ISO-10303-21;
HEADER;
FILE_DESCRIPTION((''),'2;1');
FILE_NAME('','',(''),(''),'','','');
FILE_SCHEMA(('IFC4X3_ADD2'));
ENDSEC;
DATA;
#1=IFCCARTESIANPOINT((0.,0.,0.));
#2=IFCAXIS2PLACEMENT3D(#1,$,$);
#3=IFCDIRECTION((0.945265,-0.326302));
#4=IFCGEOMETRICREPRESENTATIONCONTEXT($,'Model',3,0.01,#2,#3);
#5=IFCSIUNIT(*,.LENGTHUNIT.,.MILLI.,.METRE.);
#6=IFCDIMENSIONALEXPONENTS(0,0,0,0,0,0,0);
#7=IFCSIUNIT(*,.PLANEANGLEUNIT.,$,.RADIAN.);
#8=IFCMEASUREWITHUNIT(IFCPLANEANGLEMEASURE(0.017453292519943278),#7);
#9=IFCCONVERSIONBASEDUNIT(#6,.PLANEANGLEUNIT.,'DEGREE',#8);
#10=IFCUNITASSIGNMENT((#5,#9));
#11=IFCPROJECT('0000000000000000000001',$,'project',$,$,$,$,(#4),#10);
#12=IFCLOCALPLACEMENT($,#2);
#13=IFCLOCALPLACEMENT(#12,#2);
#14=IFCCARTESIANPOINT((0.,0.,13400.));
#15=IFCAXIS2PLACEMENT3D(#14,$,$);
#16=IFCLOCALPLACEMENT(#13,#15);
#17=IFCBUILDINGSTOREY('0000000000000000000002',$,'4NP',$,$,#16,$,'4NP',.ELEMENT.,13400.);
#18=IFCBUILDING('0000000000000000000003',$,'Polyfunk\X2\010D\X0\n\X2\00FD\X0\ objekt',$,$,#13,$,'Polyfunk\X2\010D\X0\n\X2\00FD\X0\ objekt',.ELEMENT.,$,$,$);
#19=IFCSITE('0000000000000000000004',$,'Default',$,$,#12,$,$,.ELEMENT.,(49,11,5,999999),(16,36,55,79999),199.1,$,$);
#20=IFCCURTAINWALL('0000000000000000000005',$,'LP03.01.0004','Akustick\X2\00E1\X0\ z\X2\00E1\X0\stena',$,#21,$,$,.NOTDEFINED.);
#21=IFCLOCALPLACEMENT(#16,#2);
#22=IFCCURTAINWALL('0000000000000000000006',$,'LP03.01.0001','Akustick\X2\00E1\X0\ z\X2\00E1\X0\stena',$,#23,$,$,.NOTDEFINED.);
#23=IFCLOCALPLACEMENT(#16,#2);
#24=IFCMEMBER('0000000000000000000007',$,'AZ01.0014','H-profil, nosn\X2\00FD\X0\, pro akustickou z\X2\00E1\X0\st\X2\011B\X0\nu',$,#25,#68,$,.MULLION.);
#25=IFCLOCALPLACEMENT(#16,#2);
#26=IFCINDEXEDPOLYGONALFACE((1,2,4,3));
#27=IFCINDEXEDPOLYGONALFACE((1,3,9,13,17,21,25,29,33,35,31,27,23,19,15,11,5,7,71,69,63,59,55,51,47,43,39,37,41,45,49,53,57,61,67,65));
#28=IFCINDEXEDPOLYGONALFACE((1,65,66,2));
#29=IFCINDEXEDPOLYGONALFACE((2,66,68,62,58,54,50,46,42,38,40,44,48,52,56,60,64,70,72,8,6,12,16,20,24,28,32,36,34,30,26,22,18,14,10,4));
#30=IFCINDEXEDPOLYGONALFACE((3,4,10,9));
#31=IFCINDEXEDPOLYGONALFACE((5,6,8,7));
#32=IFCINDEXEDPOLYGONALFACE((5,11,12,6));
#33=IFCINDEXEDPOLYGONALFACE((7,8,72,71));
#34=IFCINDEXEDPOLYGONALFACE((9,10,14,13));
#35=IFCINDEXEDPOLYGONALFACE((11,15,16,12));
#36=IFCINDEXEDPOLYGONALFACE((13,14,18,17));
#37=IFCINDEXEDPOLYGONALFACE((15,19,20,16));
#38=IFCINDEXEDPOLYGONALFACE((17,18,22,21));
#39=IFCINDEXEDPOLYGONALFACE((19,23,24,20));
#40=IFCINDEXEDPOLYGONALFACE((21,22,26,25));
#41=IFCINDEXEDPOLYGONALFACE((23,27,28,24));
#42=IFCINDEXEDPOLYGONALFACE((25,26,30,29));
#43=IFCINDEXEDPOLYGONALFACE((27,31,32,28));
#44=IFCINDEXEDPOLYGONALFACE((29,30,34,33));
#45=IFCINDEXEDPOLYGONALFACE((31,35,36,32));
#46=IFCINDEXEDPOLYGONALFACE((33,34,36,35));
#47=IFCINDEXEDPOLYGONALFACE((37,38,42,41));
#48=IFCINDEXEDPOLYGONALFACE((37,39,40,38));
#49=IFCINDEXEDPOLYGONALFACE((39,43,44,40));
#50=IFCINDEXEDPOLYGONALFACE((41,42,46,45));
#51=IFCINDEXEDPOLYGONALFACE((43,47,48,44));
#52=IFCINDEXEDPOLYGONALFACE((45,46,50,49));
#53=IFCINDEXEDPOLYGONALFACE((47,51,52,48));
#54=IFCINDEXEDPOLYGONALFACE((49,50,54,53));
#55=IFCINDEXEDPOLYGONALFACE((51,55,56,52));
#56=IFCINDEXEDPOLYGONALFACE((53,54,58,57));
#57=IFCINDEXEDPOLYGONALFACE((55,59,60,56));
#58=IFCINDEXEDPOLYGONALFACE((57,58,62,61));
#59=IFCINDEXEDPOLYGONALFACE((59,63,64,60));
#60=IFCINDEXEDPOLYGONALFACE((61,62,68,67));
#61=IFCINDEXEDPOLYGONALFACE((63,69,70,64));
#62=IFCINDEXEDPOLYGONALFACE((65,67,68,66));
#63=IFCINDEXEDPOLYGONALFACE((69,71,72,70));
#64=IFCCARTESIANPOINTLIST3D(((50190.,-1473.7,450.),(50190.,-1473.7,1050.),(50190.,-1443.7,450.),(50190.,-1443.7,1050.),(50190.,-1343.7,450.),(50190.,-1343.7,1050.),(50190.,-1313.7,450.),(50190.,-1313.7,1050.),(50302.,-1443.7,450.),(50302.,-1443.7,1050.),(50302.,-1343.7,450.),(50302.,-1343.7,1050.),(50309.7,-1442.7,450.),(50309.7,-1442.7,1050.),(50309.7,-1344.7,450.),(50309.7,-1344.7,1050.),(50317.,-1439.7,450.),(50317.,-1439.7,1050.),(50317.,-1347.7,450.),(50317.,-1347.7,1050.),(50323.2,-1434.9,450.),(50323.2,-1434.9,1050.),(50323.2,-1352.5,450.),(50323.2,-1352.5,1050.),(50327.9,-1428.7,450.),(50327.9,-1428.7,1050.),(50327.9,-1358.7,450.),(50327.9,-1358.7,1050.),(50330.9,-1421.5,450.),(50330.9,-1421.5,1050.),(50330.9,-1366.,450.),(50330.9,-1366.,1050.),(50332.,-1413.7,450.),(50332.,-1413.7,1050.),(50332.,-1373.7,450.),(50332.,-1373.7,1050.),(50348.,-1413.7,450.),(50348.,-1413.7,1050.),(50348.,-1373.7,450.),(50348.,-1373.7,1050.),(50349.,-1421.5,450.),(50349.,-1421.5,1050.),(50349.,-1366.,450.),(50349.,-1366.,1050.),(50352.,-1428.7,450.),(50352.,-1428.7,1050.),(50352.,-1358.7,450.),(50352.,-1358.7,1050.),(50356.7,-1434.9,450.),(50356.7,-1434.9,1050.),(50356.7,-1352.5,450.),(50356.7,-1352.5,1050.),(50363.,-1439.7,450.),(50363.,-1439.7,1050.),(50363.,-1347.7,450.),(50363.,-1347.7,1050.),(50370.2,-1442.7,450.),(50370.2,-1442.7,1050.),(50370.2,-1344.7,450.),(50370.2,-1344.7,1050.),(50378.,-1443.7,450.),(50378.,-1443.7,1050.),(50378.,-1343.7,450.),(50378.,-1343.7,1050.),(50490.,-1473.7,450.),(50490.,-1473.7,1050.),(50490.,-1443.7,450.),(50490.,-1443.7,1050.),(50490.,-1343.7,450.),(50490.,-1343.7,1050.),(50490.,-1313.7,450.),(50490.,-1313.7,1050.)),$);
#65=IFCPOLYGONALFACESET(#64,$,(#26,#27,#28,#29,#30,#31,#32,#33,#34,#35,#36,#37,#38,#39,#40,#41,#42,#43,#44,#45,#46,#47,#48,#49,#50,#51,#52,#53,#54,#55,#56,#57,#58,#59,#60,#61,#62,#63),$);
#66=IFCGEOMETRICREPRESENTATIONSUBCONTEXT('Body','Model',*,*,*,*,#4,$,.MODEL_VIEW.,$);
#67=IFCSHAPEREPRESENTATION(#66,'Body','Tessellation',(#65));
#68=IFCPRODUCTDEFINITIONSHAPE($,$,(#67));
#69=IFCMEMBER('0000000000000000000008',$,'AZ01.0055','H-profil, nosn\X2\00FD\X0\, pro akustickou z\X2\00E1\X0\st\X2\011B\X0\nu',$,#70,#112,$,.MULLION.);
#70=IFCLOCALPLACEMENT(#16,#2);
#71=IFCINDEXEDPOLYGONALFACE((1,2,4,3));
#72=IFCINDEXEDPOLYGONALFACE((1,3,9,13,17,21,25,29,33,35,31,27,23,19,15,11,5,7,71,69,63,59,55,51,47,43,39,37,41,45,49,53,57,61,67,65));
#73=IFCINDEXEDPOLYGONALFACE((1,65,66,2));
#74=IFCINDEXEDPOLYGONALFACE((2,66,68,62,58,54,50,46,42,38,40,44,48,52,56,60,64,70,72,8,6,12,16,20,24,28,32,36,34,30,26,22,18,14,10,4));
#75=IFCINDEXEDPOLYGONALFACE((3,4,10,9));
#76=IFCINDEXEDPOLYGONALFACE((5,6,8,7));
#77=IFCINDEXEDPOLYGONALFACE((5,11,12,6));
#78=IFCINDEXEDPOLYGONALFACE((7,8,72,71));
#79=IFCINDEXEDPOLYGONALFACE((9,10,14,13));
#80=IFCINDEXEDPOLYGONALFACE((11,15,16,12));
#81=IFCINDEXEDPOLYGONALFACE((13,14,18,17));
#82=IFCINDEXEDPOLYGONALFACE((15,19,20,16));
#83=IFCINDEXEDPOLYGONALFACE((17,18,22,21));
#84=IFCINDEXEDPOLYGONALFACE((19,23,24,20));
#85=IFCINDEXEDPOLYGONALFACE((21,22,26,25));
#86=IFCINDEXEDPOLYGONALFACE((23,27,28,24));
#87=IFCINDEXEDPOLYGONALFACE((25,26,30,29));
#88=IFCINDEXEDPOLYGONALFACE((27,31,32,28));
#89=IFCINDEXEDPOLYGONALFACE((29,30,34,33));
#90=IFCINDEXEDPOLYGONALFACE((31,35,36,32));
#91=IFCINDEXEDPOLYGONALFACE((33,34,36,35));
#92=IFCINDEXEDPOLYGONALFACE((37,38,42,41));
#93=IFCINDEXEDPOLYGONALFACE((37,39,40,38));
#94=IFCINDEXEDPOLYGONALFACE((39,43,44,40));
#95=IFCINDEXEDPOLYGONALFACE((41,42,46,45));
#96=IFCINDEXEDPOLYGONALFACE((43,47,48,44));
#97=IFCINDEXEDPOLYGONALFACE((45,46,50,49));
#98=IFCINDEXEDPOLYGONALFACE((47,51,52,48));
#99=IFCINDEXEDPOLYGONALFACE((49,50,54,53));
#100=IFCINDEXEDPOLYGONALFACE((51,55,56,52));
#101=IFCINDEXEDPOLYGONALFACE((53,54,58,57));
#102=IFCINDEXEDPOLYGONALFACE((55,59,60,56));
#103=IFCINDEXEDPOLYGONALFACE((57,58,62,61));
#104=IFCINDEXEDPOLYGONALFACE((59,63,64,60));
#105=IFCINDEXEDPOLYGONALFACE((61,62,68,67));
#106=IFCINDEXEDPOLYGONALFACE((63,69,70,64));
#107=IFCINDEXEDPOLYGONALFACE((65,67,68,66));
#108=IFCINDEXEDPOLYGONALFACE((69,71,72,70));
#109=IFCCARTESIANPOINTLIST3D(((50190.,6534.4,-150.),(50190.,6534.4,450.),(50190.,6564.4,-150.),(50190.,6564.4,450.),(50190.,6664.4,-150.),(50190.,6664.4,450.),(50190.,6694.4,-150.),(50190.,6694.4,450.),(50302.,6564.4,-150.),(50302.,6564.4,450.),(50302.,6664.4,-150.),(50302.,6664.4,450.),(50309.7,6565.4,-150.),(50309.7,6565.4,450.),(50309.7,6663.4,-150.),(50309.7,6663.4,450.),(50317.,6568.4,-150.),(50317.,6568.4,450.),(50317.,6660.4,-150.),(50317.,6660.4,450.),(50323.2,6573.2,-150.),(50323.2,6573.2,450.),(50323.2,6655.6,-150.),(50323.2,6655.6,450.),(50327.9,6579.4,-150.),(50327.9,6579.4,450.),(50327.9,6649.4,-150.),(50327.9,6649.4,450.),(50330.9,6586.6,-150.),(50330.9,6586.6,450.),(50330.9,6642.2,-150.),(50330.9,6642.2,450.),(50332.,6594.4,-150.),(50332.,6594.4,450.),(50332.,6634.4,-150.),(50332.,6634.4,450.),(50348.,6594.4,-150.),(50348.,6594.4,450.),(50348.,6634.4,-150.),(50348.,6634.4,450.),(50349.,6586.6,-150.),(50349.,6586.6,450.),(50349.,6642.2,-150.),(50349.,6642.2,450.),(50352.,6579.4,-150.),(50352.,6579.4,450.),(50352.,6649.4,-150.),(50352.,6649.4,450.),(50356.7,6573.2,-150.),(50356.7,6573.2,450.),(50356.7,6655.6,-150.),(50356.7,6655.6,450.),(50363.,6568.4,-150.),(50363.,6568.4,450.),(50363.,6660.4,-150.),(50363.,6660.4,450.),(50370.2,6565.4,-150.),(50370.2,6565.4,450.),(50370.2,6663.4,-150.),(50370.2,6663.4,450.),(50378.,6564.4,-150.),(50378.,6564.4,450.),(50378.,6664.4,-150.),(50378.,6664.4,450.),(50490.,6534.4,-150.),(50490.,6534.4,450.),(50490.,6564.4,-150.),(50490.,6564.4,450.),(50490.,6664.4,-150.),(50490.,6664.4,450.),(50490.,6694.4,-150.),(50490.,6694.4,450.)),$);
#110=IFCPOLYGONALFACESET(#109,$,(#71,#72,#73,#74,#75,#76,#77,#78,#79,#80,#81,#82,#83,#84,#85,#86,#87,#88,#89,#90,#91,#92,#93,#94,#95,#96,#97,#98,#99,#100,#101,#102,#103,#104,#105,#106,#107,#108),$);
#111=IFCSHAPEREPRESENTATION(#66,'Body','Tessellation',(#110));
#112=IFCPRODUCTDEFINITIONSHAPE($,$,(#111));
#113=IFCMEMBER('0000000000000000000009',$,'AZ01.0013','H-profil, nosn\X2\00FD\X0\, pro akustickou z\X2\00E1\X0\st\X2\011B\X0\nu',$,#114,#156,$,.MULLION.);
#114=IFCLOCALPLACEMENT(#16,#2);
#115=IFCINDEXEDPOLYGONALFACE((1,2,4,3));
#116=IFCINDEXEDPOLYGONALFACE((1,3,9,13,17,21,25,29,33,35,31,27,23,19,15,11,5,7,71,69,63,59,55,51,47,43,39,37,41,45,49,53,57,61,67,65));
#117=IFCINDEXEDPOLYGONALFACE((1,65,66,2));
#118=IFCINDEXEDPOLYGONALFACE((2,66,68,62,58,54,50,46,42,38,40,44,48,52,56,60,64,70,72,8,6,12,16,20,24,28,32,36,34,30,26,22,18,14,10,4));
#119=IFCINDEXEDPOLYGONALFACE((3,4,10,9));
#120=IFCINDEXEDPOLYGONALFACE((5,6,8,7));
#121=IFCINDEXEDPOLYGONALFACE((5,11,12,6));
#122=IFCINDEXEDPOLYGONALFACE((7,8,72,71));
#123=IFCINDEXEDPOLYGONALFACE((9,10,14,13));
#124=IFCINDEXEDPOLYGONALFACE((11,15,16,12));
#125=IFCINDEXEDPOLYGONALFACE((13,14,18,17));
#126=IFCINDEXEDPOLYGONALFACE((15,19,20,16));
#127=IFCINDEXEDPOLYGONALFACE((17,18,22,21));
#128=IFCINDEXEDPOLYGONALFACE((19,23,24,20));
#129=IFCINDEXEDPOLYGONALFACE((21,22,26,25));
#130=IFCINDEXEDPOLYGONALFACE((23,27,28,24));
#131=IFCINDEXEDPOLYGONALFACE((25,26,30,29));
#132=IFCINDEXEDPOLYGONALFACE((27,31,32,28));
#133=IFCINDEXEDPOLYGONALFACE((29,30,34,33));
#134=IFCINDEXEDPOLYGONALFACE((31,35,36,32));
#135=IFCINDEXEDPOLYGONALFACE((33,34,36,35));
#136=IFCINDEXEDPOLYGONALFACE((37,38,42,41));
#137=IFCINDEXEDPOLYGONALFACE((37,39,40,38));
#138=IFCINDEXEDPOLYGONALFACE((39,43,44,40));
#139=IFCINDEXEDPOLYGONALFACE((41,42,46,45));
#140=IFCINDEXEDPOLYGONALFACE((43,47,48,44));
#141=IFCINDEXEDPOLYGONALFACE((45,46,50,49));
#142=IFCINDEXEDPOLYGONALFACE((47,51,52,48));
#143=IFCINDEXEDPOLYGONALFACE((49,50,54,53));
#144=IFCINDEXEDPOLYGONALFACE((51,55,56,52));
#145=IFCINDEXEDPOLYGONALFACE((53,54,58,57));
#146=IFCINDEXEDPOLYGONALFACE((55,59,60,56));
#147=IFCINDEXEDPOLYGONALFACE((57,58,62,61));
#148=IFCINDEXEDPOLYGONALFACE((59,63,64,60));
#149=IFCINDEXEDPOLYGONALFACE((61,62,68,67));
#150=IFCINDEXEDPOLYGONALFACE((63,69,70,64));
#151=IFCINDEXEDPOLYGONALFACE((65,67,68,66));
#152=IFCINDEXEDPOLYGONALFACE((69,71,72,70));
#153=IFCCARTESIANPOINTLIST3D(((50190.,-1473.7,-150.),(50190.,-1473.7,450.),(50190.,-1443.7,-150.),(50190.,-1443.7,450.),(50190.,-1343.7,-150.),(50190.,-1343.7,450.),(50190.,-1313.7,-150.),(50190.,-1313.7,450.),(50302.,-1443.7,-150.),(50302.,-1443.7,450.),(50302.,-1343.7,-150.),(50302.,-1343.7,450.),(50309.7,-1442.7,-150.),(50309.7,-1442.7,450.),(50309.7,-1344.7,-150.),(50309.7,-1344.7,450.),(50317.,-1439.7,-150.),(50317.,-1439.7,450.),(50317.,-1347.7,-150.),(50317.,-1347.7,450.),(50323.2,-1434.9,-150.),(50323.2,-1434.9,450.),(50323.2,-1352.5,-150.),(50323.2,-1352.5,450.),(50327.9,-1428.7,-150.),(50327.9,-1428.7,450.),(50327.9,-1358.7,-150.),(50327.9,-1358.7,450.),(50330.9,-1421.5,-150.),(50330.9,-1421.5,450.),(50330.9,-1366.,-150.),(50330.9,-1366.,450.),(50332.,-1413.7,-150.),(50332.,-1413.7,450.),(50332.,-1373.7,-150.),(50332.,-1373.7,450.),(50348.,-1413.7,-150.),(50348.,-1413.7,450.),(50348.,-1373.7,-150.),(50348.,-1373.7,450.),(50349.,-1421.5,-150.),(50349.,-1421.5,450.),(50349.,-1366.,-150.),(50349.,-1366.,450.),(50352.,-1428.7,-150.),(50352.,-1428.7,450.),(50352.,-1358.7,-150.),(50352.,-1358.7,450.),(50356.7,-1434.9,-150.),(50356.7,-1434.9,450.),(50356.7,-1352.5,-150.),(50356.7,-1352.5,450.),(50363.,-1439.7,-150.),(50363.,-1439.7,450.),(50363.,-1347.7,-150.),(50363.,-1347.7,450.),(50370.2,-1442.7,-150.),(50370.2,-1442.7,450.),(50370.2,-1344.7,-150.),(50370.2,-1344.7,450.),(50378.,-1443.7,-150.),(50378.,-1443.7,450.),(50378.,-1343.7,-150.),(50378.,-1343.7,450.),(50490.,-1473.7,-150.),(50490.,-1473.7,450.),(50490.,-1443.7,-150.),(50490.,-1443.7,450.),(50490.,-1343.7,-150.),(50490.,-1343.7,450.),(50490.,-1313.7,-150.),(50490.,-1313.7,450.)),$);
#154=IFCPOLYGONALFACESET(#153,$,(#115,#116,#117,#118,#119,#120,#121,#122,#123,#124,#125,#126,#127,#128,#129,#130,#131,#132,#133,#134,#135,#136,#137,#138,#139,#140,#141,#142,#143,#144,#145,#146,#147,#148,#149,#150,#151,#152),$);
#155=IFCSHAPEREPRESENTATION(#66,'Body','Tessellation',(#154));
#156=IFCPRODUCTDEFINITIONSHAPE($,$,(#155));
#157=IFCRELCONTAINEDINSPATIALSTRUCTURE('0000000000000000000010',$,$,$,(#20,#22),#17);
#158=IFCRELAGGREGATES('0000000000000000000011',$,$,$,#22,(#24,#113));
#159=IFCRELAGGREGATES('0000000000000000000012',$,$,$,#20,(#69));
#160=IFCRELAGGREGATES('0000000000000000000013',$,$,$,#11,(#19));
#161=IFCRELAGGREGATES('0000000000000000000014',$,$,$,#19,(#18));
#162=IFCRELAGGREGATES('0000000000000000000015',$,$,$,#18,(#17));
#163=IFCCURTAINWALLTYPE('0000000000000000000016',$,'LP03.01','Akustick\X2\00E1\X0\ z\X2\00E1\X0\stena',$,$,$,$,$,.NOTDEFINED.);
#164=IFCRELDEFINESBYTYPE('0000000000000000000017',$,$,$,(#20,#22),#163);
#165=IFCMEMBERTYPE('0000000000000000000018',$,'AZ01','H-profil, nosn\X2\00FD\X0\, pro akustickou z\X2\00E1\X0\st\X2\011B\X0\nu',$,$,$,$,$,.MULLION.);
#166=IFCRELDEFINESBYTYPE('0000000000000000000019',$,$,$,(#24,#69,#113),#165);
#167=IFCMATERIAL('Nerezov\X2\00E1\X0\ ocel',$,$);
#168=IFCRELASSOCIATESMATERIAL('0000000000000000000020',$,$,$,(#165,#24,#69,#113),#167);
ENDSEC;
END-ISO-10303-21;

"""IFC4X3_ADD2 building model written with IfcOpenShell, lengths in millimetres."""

from ifc_helpers import new_model, entity, si_unit, converted_unit, direction, frame, frame_2d, origin, place, context, subcontext, project, spatial, polyline, circle_curve, parameter, trimmed, segment, composite_curve, outline, extrude, source, transform, mapped, material, material_profile, profile_set, profile_usage, type_object, element, aggregate, save


model = new_model("IFC4X3_ADD2")

# Units and contexts
model_context = context("Model", 3, precision=0.01, world=origin(), true_north=direction((0.945265, -0.326302)))
body_context = subcontext(model_context, "Body", "Model", "MODEL_VIEW")
ifc_project = project(units=[si_unit("LENGTHUNIT", "METRE", prefix="MILLI"), converted_unit("PLANEANGLEUNIT", "DEGREE", entity("IfcPlaneAngleMeasure", 0.017453292519943278), si_unit("PLANEANGLEUNIT", "RADIAN"), dimensions=[0, 0, 0, 0, 0, 0, 0])], contexts=[model_context])

# Site, building, storey
site_placement = place(None, origin())
site = spatial("IfcSite", under=ifc_project, at=site_placement, Name="Default", CompositionType="ELEMENT", RefLatitude=(49, 11, 5, 999999), RefLongitude=(16, 36, 55, 79999), RefElevation=199.1)
building_placement = place(site_placement, origin())
building = spatial("IfcBuilding", under=site, at=building_placement, Name="Polyfunkčný objekt", LongName="Polyfunkčný objekt", CompositionType="ELEMENT")
storey_placement = place(building_placement, frame((0.0, 0.0, 13400.0)))
storey = spatial("IfcBuildingStorey", under=building, at=storey_placement, Name="4NP", LongName="4NP", CompositionType="ELEMENT", Elevation=13400.0)

# Curtain walls, member
curtain_wall_type = type_object("IfcCurtainWallType", Name="LP03.01", Description="Akustická zástena", PredefinedType="NOTDEFINED")
curtain_wall_1_placement = place(storey_placement, frame((0.0, 0.0, -13400.0)))
curtain_wall_1 = element("IfcCurtainWall", 1, at=curtain_wall_1_placement, inside=storey, type_object=curtain_wall_type, Name="LP03.01.0004", Description="Akustická zástena", PredefinedType="NOTDEFINED")
ifc_material_1 = material(Name="Nerezová ocel")
ifc_material_profile = material_profile(ifc_material_1, outline(composite_curve([segment(polyline([(50.0, -150.0), (80.0, -150.0)]), True, "CONTINUOUS"), segment(polyline([(80.0, -150.0), (80.0, 150.0)]), True, "CONTINUOUS"), segment(polyline([(80.0, 150.0), (50.0, 150.0)]), True, "CONTINUOUS"), segment(polyline([(50.0, 150.0), (50.0, 38.0)]), True, "CONTINUOUS"), segment(trimmed(circle_curve(frame_2d((20.0, 38.0), x_axis=(0.0, 1.0)), 30.0), [parameter(180.0)], [parameter(270.0)], True, "PARAMETER"), False, "CONTINUOUS"), segment(polyline([(20.0, 8.0), (-20.0, 8.0)]), True, "CONTINUOUS"), segment(trimmed(circle_curve(frame_2d((-20.0, 38.0), x_axis=(0.0, 1.0)), 30.0), [parameter(90.0)], [parameter(180.0)], True, "PARAMETER"), False, "CONTINUOUS"), segment(polyline([(-50.0, 38.0), (-50.0, 150.0)]), True, "CONTINUOUS"), segment(polyline([(-50.0, 150.0), (-80.0, 150.0)]), True, "CONTINUOUS"), segment(polyline([(-80.0, 150.0), (-80.0, -150.0)]), True, "CONTINUOUS"), segment(polyline([(-80.0, -150.0), (-50.0, -150.0)]), True, "CONTINUOUS"), segment(polyline([(-50.0, -150.0), (-50.0, -38.0)]), True, "CONTINUOUS"), segment(trimmed(circle_curve(frame_2d((-20.0, -38.0), x_axis=(0.0, 1.0)), 30.0), [parameter(0.0)], [parameter(90.0)], True, "PARAMETER"), False, "CONTINUOUS"), segment(polyline([(-20.0, -8.0), (20.0, -8.0)]), True, "CONTINUOUS"), segment(trimmed(circle_curve(frame_2d((20.0, -38.0), x_axis=(0.0, 1.0)), 30.0), [parameter(270.0)], [parameter(0.0)], True, "PARAMETER"), False, "CONTINUOUS"), segment(polyline([(50.0, -38.0), (50.0, -150.0)]), True, "CONTINUOUS")], self_intersect=False)), Name="Profil zástena")
ifc_profile_set = profile_set([ifc_material_profile], Name="Profil zástena")
ifc_profile_usage = profile_usage(ifc_profile_set)
member_type = type_object("IfcMemberType", Name="AZ01", Description="H-profil, nosný, pro akustickou zástěnu", PredefinedType="MULLION", material=ifc_profile_set)
shared_shape_1 = source(origin(), body_context, "Body", "SweptSolid", [
    extrude(outline(composite_curve([segment(polyline([(-150.0, -50.0), (-150.0, -80.0)]), True, "CONTINUOUS"), segment(polyline([(-150.0, -80.0), (150.0, -80.0)]), True, "CONTINUOUS"), segment(polyline([(150.0, -80.0), (150.0, -50.0)]), True, "CONTINUOUS"), segment(polyline([(150.0, -50.0), (38.0, -50.0)]), True, "CONTINUOUS"), segment(trimmed(circle_curve(frame_2d((38.0, -20.0), x_axis=(1.0, 0.0)), 30.0), [parameter(180.0)], [parameter(270.0)], True, "PARAMETER"), False, "CONTINUOUS"), segment(polyline([(8.0, -20.0), (8.0, 20.0)]), True, "CONTINUOUS"), segment(trimmed(circle_curve(frame_2d((38.0, 20.0), x_axis=(1.0, 0.0)), 30.0), [parameter(90.0)], [parameter(180.0)], True, "PARAMETER"), False, "CONTINUOUS"), segment(polyline([(38.0, 50.0), (150.0, 50.0)]), True, "CONTINUOUS"), segment(polyline([(150.0, 50.0), (150.0, 80.0)]), True, "CONTINUOUS"), segment(polyline([(150.0, 80.0), (-150.0, 80.0)]), True, "CONTINUOUS"), segment(polyline([(-150.0, 80.0), (-150.0, 50.0)]), True, "CONTINUOUS"), segment(polyline([(-150.0, 50.0), (-38.0, 50.0)]), True, "CONTINUOUS"), segment(trimmed(circle_curve(frame_2d((-38.0, 20.0), x_axis=(1.0, 0.0)), 30.0), [parameter(0.0)], [parameter(90.0)], True, "PARAMETER"), False, "CONTINUOUS"), segment(polyline([(-8.0, 20.0), (-8.0, -20.0)]), True, "CONTINUOUS"), segment(trimmed(circle_curve(frame_2d((-38.0, -20.0), x_axis=(1.0, 0.0)), 30.0), [parameter(270.0)], [parameter(0.0)], True, "PARAMETER"), False, "CONTINUOUS"), segment(polyline([(-38.0, -50.0), (-150.0, -50.0)]), True, "CONTINUOUS")], self_intersect=False)), frame((-150.0, 0.0, -600.0), z_axis=(0.0, 0.0, -1.0), x_axis=(-1.0, 0.0, 0.0)), (0.0, 0.0, -1.0), 600.0),
])
curtain_wall_2_placement = place(storey_placement, frame((0.0, 0.0, -13400.0)))
curtain_wall_2 = element("IfcCurtainWall", 2, at=curtain_wall_2_placement, inside=storey, type_object=curtain_wall_type, Name="LP03.01.0001", Description="Akustická zástena", PredefinedType="NOTDEFINED")
member_1_placement = place(curtain_wall_2_placement, frame((50190.0, -1393.7, 14450.0), z_axis=(0.0, 0.0, 1.0), x_axis=(-1.0, 0.0, 0.0)))
member_1 = element("IfcMember", 3, at=member_1_placement, type_object=member_type, material=ifc_profile_usage, Name="AZ01.0014", Description="H-profil, nosný, pro akustickou zástěnu", PredefinedType="MULLION", context=body_context, shape_type="MappedRepresentation", body=[
    mapped(shared_shape_1, transform((0.0, 0.0, 0.0), scale=1.0)),
])

# Members
shared_shape_2 = source(origin(), body_context, "Body", "SweptSolid", [
    extrude(outline(composite_curve([segment(polyline([(-150.0, -50.0), (-150.0, -80.0)]), True, "CONTINUOUS"), segment(polyline([(-150.0, -80.0), (150.0, -80.0)]), True, "CONTINUOUS"), segment(polyline([(150.0, -80.0), (150.0, -50.0)]), True, "CONTINUOUS"), segment(polyline([(150.0, -50.0), (38.0, -50.0)]), True, "CONTINUOUS"), segment(trimmed(circle_curve(frame_2d((38.0, -20.0), x_axis=(1.0, 0.0)), 30.0), [parameter(180.0)], [parameter(270.0)], True, "PARAMETER"), False, "CONTINUOUS"), segment(polyline([(8.0, -20.0), (8.0, 20.0)]), True, "CONTINUOUS"), segment(trimmed(circle_curve(frame_2d((38.0, 20.0), x_axis=(1.0, 0.0)), 30.0), [parameter(90.0)], [parameter(180.0)], True, "PARAMETER"), False, "CONTINUOUS"), segment(polyline([(38.0, 50.0), (150.0, 50.0)]), True, "CONTINUOUS"), segment(polyline([(150.0, 50.0), (150.0, 80.0)]), True, "CONTINUOUS"), segment(polyline([(150.0, 80.0), (-150.0, 80.0)]), True, "CONTINUOUS"), segment(polyline([(-150.0, 80.0), (-150.0, 50.0)]), True, "CONTINUOUS"), segment(polyline([(-150.0, 50.0), (-38.0, 50.0)]), True, "CONTINUOUS"), segment(trimmed(circle_curve(frame_2d((-38.0, 20.0), x_axis=(1.0, 0.0)), 30.0), [parameter(0.0)], [parameter(90.0)], True, "PARAMETER"), False, "CONTINUOUS"), segment(polyline([(-8.0, 20.0), (-8.0, -20.0)]), True, "CONTINUOUS"), segment(trimmed(circle_curve(frame_2d((-38.0, -20.0), x_axis=(1.0, 0.0)), 30.0), [parameter(270.0)], [parameter(0.0)], True, "PARAMETER"), False, "CONTINUOUS"), segment(polyline([(-38.0, -50.0), (-150.0, -50.0)]), True, "CONTINUOUS")], self_intersect=False)), frame((-150.0, 0.0, -600.0), z_axis=(0.0, 0.0, -1.0), x_axis=(-1.0, 0.0, 0.0)), (0.0, 0.0, -1.0), 600.0),
])
member_2_placement = place(curtain_wall_1_placement, frame((50190.0, 6614.4, 13850.0), z_axis=(0.0, 0.0, 1.0), x_axis=(-1.0, 0.0, 0.0)))
member_2 = element("IfcMember", 4, at=member_2_placement, type_object=member_type, material=ifc_profile_usage, Name="AZ01.0055", Description="H-profil, nosný, pro akustickou zástěnu", PredefinedType="MULLION", context=body_context, shape_type="MappedRepresentation", body=[
    mapped(shared_shape_2, transform((0.0, 0.0, 0.0), scale=1.0)),
])
member_3_placement = place(curtain_wall_2_placement, frame((50190.0, -1393.7, 13850.0), z_axis=(0.0, 0.0, 1.0), x_axis=(-1.0, 0.0, 0.0)))
member_3 = element("IfcMember", 5, at=member_3_placement, type_object=member_type, material=ifc_profile_usage, Name="AZ01.0013", Description="H-profil, nosný, pro akustickou zástěnu", PredefinedType="MULLION", context=body_context, shape_type="MappedRepresentation", body=[
    mapped(shared_shape_2, transform((0.0, 0.0, 0.0), scale=1.0)),
])
aggregate(curtain_wall_2, [member_1, member_3])

aggregate(curtain_wall_1, [member_2])

save(model, "model.ifc")
